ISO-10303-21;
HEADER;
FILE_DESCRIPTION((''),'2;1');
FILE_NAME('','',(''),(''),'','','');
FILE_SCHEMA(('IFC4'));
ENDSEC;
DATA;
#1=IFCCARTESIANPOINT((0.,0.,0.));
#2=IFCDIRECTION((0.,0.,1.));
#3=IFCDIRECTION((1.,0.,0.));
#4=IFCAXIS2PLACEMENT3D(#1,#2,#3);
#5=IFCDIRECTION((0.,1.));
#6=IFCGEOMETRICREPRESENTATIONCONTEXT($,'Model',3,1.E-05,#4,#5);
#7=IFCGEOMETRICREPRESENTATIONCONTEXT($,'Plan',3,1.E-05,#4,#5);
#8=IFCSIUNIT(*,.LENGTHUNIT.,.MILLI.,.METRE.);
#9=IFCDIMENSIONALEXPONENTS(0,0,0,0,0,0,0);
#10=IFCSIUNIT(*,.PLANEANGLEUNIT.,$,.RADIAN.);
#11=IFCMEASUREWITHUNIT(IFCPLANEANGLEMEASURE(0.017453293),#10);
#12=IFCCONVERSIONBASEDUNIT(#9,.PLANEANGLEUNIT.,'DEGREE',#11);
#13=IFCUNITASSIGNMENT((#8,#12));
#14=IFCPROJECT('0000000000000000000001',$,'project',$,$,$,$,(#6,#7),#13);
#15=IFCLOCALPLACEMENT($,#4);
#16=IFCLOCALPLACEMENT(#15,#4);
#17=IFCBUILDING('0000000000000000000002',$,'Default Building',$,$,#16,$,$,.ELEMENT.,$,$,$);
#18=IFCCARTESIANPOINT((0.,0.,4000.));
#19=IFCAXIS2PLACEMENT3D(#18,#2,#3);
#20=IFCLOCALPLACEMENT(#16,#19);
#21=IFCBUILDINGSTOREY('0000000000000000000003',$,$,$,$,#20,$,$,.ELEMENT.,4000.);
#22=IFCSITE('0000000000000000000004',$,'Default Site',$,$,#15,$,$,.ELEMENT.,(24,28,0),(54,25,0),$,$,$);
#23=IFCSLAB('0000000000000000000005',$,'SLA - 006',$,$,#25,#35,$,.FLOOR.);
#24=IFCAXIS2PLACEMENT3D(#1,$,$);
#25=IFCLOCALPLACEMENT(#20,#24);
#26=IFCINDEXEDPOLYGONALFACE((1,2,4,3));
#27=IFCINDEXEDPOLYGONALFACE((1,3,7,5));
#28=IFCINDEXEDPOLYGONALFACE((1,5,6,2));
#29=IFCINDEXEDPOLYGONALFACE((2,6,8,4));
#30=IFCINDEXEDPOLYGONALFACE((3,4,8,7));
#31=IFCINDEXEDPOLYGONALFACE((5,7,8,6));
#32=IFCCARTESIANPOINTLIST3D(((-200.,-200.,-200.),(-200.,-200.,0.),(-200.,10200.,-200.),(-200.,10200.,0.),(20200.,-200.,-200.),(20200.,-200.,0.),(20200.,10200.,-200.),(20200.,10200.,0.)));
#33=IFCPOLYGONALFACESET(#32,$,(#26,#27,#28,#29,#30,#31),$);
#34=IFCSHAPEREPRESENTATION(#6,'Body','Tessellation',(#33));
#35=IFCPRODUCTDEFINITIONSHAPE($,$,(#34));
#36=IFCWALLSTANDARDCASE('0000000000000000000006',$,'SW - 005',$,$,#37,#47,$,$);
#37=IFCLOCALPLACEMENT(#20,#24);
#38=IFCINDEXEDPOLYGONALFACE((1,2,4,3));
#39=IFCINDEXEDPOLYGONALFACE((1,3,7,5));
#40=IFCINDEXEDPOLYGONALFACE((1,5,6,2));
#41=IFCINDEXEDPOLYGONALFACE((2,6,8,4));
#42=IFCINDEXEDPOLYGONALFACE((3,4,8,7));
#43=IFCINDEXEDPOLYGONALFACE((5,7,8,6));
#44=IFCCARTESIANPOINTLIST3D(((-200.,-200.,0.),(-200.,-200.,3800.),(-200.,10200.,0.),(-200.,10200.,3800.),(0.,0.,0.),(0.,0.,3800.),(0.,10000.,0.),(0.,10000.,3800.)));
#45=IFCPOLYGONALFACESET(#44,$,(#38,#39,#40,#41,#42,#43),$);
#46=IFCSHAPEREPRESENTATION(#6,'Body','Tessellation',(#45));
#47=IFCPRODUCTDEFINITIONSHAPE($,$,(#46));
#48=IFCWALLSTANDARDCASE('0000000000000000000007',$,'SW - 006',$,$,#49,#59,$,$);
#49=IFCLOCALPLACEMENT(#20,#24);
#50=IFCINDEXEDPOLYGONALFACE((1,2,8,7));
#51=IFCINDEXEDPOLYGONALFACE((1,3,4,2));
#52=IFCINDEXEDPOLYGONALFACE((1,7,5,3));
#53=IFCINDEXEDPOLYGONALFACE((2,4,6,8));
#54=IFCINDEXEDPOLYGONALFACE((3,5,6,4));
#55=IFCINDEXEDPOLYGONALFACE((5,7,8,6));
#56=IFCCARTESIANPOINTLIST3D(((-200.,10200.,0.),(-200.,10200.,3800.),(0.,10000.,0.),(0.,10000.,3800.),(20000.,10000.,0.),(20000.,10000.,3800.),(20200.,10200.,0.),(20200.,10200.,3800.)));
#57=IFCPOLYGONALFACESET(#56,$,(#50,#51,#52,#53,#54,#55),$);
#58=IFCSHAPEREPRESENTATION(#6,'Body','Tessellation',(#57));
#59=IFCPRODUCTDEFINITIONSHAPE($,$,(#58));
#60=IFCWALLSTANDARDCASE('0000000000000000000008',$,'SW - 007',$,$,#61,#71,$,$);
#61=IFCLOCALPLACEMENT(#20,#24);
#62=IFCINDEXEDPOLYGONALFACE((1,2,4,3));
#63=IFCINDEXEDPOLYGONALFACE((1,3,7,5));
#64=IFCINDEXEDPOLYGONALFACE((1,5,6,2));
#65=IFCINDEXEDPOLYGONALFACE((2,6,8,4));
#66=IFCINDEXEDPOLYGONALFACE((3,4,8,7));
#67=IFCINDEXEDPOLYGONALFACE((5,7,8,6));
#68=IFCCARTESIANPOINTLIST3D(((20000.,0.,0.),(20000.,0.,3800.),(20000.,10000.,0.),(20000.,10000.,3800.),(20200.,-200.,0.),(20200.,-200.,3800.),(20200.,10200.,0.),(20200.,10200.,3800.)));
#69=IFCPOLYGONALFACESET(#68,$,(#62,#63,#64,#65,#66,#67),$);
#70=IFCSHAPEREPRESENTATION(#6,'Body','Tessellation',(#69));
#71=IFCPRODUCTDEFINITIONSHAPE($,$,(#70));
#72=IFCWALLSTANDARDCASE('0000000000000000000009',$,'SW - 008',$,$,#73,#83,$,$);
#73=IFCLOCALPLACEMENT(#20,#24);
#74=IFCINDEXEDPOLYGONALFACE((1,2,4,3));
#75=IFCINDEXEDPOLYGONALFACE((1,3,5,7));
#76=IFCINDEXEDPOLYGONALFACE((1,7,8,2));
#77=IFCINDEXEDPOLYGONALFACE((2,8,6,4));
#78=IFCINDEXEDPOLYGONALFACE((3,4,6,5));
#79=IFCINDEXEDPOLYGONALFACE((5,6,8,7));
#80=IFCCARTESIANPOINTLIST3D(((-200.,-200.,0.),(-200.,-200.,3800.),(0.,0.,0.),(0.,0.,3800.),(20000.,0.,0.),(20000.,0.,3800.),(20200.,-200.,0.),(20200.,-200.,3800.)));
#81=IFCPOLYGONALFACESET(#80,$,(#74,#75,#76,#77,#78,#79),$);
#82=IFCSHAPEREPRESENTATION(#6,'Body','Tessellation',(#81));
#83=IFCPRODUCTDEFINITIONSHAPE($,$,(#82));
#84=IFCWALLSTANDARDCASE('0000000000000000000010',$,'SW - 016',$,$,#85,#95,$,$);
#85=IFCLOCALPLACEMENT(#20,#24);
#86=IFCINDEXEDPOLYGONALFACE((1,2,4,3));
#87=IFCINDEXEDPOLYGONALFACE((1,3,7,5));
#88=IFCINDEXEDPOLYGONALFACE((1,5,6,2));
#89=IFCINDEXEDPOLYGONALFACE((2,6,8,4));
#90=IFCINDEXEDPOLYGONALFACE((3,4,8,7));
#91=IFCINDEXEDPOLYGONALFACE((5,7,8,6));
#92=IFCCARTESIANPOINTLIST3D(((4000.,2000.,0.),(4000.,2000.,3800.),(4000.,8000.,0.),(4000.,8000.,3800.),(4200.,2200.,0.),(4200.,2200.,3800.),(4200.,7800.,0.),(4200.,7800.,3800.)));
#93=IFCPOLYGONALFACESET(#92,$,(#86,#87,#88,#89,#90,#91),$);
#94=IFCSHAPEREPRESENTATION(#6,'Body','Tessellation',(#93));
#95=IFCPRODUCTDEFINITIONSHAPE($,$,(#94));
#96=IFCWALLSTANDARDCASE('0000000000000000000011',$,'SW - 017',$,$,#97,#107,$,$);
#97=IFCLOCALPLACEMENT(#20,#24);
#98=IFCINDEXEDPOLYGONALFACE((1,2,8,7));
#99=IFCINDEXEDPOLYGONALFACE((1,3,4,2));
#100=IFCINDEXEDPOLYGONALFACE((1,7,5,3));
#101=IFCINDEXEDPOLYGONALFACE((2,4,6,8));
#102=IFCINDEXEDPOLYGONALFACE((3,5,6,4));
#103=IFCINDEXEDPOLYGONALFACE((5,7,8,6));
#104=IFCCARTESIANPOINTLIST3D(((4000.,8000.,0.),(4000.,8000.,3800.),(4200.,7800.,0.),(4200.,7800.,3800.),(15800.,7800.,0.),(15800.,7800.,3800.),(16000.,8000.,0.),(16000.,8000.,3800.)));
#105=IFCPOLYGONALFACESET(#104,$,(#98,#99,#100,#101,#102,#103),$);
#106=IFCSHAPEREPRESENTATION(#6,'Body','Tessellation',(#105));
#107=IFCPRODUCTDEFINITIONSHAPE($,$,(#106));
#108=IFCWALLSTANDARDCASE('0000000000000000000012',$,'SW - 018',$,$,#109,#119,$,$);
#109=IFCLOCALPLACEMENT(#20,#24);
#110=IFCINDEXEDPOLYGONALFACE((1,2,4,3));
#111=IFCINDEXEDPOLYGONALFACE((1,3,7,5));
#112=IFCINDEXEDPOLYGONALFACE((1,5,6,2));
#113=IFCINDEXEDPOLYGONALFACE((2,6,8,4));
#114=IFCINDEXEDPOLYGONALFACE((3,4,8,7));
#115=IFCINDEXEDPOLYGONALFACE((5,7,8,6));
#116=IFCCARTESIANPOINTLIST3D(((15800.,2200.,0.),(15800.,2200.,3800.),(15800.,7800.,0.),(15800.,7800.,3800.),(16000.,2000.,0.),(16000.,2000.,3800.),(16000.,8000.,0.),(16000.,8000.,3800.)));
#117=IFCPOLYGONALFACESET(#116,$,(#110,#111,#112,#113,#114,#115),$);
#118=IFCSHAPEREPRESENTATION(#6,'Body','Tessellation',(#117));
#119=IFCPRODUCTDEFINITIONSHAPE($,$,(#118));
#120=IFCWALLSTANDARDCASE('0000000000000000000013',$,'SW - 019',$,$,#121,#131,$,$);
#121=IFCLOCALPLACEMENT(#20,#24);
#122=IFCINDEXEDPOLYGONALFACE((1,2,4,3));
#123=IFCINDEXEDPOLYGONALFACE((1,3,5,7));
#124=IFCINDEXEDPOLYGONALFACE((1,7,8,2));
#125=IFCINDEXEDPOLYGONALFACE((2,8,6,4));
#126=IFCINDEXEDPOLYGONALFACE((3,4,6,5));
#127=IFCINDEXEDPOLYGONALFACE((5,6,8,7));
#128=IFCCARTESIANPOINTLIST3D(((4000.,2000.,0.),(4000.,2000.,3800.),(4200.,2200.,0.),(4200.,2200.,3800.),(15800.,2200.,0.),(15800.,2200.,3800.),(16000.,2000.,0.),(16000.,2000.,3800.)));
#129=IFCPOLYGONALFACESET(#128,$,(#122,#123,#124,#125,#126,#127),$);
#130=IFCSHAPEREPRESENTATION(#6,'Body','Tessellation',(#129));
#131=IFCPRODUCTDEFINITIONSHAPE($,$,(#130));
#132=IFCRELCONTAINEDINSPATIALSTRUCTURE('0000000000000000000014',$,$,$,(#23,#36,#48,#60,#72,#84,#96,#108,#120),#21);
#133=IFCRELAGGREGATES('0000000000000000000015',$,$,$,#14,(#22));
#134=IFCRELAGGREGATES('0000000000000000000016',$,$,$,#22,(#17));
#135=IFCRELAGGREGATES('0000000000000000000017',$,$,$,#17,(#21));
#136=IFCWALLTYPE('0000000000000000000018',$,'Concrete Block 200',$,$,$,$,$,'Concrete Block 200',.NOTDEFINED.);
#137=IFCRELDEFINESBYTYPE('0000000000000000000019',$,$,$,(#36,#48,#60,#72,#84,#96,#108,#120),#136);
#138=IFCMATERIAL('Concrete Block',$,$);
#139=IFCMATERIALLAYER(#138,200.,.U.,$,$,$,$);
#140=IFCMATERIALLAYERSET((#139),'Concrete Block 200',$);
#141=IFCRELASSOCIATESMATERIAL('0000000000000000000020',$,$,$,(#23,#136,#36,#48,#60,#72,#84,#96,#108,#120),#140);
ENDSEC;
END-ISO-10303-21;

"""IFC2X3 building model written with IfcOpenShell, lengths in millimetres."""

from ifc_helpers import new_model, entity, si_unit, converted_unit, direction, frame, origin_with_axes, place, context, project, spatial, polyline, outline, extrude, material, layer, layer_set, layer_usage, type_object, element, save


model = new_model("IFC2X3")

# Units and contexts
model_context = context("Model", 3, precision=1e-05, world=origin_with_axes(), true_north=direction((0.0, 1.0)))
plan_context = context("Plan", 3, precision=1e-05, world=origin_with_axes(), true_north=direction((0.0, 1.0)))
ifc_project = project(units=[si_unit("LENGTHUNIT", "METRE", prefix="MILLI"), converted_unit("PLANEANGLEUNIT", "DEGREE", entity("IfcPlaneAngleMeasure", 0.017453293), si_unit("PLANEANGLEUNIT", "RADIAN"), dimensions=[0, 0, 0, 0, 0, 0, 0])], contexts=[model_context, plan_context])

# Site, building, storey
site_placement = place(None, origin_with_axes())
site = spatial("IfcSite", under=ifc_project, at=site_placement, Name="Default Site", CompositionType="ELEMENT", RefLatitude=(24, 28, 0), RefLongitude=(54, 25, 0))
building_placement = place(site_placement, origin_with_axes())
building = spatial("IfcBuilding", under=site, at=building_placement, Name="Default Building", CompositionType="ELEMENT")
storey_placement = place(building_placement, frame((0.0, 0.0, 4000.0), z_axis=(0.0, 0.0, 1.0), x_axis=(1.0, 0.0, 0.0)))
storey = spatial("IfcBuildingStorey", under=building, at=storey_placement, CompositionType="ELEMENT", Elevation=4000.0)

# Slab
ifc_material = material(Name="Concrete Block")
ifc_layer = layer(ifc_material, 200.0, ventilated="UNKNOWN")
ifc_layer_set = layer_set([ifc_layer], Name="Concrete Block 200")
ifc_layer_usage_1 = layer_usage(ifc_layer_set, "AXIS3", "NEGATIVE", 200.0)
slab_placement = place(storey_placement, frame((-200.0, 10200.0, -200.0), z_axis=(0.0, 0.0, 1.0), x_axis=(1.0, 0.0, 0.0)))
element("IfcSlab", 1, at=slab_placement, inside=storey, material=ifc_layer_usage_1, Name="SLA - 006", PredefinedType="FLOOR", context=model_context, shape_type="SweptSolid", body=[
    extrude(outline(polyline([(0.0, 0.0), (20400.0, 0.0), (20400.0, -10400.0), (0.0, -10400.0), (0.0, 0.0)])), origin_with_axes(), (0.0, 0.0, 1.0), 200.0),
])

# Walls
ifc_layer_usage_2 = layer_usage(ifc_layer_set, "AXIS2", "POSITIVE", 0.0)
wall_type = type_object("IfcWallType", Name="Concrete Block 200", ElementType="Concrete Block 200", PredefinedType="NOTDEFINED", material=ifc_layer_set)
wall_1_placement = place(storey_placement, frame((0.0, 0.0, 0.0), z_axis=(0.0, 0.0, 1.0), x_axis=(0.0, 1.0, 0.0)))
element("IfcWallStandardCase", 2, at=wall_1_placement, inside=storey, type_object=wall_type, material=ifc_layer_usage_2, Name="SW - 005", context=model_context, shape_type="SweptSolid", body=[
    extrude(outline(polyline([(0.0, 0.0), (10000.0, 0.0), (10200.0, 200.0), (-200.0, 200.0), (0.0, 0.0)])), origin_with_axes(), (0.0, 0.0, 1.0), 3800.0),
])
ifc_layer_usage_3 = layer_usage(ifc_layer_set, "AXIS2", "POSITIVE", 0.0)
wall_2_placement = place(storey_placement, frame((0.0, 10000.0, 0.0), z_axis=(0.0, 0.0, 1.0), x_axis=(1.0, 0.0, 0.0)))
element("IfcWallStandardCase", 3, at=wall_2_placement, inside=storey, type_object=wall_type, material=ifc_layer_usage_3, Name="SW - 006", context=model_context, shape_type="SweptSolid", body=[
    extrude(outline(polyline([(0.0, 0.0), (20000.0, 0.0), (20200.0, 200.0), (-200.0, 200.0), (0.0, 0.0)])), origin_with_axes(), (0.0, 0.0, 1.0), 3800.0),
])
ifc_layer_usage_4 = layer_usage(ifc_layer_set, "AXIS2", "POSITIVE", 0.0)
wall_3_placement = place(storey_placement, frame((20000.0, 10000.0, 0.0), z_axis=(0.0, 0.0, 1.0), x_axis=(0.0, -1.0, 0.0)))
element("IfcWallStandardCase", 4, at=wall_3_placement, inside=storey, type_object=wall_type, material=ifc_layer_usage_4, Name="SW - 007", context=model_context, shape_type="SweptSolid", body=[
    extrude(outline(polyline([(0.0, 0.0), (10000.0, 0.0), (10200.0, 200.0), (-200.0, 200.0), (0.0, 0.0)])), origin_with_axes(), (0.0, 0.0, 1.0), 3800.0),
])
ifc_layer_usage_5 = layer_usage(ifc_layer_set, "AXIS2", "POSITIVE", 0.0)
wall_4_placement = place(storey_placement, frame((20000.0, 0.0, 0.0), z_axis=(0.0, 0.0, 1.0), x_axis=(-1.0, 0.0, 0.0)))
element("IfcWallStandardCase", 5, at=wall_4_placement, inside=storey, type_object=wall_type, material=ifc_layer_usage_5, Name="SW - 008", context=model_context, shape_type="SweptSolid", body=[
    extrude(outline(polyline([(0.0, 0.0), (20000.0, 0.0), (20200.0, 200.0), (-200.0, 200.0), (0.0, 0.0)])), origin_with_axes(), (0.0, 0.0, 1.0), 3800.0),
])
ifc_layer_usage_6 = layer_usage(ifc_layer_set, "AXIS2", "POSITIVE", 0.0)
wall_5_placement = place(storey_placement, frame((4200.0, 2200.0, 0.0), z_axis=(0.0, 0.0, 1.0), x_axis=(0.0, 1.0, 0.0)))
element("IfcWallStandardCase", 6, at=wall_5_placement, inside=storey, type_object=wall_type, material=ifc_layer_usage_6, Name="SW - 016", context=model_context, shape_type="SweptSolid", body=[
    extrude(outline(polyline([(0.0, 0.0), (5600.0, 0.0), (5800.0, 200.0), (-200.0, 200.0), (0.0, 0.0)])), origin_with_axes(), (0.0, 0.0, 1.0), 3800.0),
])
ifc_layer_usage_7 = layer_usage(ifc_layer_set, "AXIS2", "POSITIVE", 0.0)
wall_6_placement = place(storey_placement, frame((4200.0, 7800.0, 0.0), z_axis=(0.0, 0.0, 1.0), x_axis=(1.0, 0.0, 0.0)))
element("IfcWallStandardCase", 7, at=wall_6_placement, inside=storey, type_object=wall_type, material=ifc_layer_usage_7, Name="SW - 017", context=model_context, shape_type="SweptSolid", body=[
    extrude(outline(polyline([(0.0, 0.0), (11600.0, 0.0), (11800.0, 200.0), (-200.0, 200.0), (0.0, 0.0)])), origin_with_axes(), (0.0, 0.0, 1.0), 3800.0),
])
ifc_layer_usage_8 = layer_usage(ifc_layer_set, "AXIS2", "POSITIVE", 0.0)
wall_7_placement = place(storey_placement, frame((15800.0, 7800.0, 0.0), z_axis=(0.0, 0.0, 1.0), x_axis=(0.0, -1.0, 0.0)))
element("IfcWallStandardCase", 8, at=wall_7_placement, inside=storey, type_object=wall_type, material=ifc_layer_usage_8, Name="SW - 018", context=model_context, shape_type="SweptSolid", body=[
    extrude(outline(polyline([(0.0, 0.0), (5600.0, 0.0), (5800.0, 200.0), (-200.0, 200.0), (0.0, 0.0)])), origin_with_axes(), (0.0, 0.0, 1.0), 3800.0),
])
ifc_layer_usage_9 = layer_usage(ifc_layer_set, "AXIS2", "POSITIVE", 0.0)
wall_8_placement = place(storey_placement, frame((15800.0, 2200.0, 0.0), z_axis=(0.0, 0.0, 1.0), x_axis=(-1.0, 0.0, 0.0)))
element("IfcWallStandardCase", 9, at=wall_8_placement, inside=storey, type_object=wall_type, material=ifc_layer_usage_9, Name="SW - 019", context=model_context, shape_type="SweptSolid", body=[
    extrude(outline(polyline([(0.0, 0.0), (11600.0, 0.0), (11800.0, 200.0), (-200.0, 200.0), (0.0, 0.0)])), origin_with_axes(), (0.0, 0.0, 1.0), 3800.0),
])

save(model, "model.ifc")
